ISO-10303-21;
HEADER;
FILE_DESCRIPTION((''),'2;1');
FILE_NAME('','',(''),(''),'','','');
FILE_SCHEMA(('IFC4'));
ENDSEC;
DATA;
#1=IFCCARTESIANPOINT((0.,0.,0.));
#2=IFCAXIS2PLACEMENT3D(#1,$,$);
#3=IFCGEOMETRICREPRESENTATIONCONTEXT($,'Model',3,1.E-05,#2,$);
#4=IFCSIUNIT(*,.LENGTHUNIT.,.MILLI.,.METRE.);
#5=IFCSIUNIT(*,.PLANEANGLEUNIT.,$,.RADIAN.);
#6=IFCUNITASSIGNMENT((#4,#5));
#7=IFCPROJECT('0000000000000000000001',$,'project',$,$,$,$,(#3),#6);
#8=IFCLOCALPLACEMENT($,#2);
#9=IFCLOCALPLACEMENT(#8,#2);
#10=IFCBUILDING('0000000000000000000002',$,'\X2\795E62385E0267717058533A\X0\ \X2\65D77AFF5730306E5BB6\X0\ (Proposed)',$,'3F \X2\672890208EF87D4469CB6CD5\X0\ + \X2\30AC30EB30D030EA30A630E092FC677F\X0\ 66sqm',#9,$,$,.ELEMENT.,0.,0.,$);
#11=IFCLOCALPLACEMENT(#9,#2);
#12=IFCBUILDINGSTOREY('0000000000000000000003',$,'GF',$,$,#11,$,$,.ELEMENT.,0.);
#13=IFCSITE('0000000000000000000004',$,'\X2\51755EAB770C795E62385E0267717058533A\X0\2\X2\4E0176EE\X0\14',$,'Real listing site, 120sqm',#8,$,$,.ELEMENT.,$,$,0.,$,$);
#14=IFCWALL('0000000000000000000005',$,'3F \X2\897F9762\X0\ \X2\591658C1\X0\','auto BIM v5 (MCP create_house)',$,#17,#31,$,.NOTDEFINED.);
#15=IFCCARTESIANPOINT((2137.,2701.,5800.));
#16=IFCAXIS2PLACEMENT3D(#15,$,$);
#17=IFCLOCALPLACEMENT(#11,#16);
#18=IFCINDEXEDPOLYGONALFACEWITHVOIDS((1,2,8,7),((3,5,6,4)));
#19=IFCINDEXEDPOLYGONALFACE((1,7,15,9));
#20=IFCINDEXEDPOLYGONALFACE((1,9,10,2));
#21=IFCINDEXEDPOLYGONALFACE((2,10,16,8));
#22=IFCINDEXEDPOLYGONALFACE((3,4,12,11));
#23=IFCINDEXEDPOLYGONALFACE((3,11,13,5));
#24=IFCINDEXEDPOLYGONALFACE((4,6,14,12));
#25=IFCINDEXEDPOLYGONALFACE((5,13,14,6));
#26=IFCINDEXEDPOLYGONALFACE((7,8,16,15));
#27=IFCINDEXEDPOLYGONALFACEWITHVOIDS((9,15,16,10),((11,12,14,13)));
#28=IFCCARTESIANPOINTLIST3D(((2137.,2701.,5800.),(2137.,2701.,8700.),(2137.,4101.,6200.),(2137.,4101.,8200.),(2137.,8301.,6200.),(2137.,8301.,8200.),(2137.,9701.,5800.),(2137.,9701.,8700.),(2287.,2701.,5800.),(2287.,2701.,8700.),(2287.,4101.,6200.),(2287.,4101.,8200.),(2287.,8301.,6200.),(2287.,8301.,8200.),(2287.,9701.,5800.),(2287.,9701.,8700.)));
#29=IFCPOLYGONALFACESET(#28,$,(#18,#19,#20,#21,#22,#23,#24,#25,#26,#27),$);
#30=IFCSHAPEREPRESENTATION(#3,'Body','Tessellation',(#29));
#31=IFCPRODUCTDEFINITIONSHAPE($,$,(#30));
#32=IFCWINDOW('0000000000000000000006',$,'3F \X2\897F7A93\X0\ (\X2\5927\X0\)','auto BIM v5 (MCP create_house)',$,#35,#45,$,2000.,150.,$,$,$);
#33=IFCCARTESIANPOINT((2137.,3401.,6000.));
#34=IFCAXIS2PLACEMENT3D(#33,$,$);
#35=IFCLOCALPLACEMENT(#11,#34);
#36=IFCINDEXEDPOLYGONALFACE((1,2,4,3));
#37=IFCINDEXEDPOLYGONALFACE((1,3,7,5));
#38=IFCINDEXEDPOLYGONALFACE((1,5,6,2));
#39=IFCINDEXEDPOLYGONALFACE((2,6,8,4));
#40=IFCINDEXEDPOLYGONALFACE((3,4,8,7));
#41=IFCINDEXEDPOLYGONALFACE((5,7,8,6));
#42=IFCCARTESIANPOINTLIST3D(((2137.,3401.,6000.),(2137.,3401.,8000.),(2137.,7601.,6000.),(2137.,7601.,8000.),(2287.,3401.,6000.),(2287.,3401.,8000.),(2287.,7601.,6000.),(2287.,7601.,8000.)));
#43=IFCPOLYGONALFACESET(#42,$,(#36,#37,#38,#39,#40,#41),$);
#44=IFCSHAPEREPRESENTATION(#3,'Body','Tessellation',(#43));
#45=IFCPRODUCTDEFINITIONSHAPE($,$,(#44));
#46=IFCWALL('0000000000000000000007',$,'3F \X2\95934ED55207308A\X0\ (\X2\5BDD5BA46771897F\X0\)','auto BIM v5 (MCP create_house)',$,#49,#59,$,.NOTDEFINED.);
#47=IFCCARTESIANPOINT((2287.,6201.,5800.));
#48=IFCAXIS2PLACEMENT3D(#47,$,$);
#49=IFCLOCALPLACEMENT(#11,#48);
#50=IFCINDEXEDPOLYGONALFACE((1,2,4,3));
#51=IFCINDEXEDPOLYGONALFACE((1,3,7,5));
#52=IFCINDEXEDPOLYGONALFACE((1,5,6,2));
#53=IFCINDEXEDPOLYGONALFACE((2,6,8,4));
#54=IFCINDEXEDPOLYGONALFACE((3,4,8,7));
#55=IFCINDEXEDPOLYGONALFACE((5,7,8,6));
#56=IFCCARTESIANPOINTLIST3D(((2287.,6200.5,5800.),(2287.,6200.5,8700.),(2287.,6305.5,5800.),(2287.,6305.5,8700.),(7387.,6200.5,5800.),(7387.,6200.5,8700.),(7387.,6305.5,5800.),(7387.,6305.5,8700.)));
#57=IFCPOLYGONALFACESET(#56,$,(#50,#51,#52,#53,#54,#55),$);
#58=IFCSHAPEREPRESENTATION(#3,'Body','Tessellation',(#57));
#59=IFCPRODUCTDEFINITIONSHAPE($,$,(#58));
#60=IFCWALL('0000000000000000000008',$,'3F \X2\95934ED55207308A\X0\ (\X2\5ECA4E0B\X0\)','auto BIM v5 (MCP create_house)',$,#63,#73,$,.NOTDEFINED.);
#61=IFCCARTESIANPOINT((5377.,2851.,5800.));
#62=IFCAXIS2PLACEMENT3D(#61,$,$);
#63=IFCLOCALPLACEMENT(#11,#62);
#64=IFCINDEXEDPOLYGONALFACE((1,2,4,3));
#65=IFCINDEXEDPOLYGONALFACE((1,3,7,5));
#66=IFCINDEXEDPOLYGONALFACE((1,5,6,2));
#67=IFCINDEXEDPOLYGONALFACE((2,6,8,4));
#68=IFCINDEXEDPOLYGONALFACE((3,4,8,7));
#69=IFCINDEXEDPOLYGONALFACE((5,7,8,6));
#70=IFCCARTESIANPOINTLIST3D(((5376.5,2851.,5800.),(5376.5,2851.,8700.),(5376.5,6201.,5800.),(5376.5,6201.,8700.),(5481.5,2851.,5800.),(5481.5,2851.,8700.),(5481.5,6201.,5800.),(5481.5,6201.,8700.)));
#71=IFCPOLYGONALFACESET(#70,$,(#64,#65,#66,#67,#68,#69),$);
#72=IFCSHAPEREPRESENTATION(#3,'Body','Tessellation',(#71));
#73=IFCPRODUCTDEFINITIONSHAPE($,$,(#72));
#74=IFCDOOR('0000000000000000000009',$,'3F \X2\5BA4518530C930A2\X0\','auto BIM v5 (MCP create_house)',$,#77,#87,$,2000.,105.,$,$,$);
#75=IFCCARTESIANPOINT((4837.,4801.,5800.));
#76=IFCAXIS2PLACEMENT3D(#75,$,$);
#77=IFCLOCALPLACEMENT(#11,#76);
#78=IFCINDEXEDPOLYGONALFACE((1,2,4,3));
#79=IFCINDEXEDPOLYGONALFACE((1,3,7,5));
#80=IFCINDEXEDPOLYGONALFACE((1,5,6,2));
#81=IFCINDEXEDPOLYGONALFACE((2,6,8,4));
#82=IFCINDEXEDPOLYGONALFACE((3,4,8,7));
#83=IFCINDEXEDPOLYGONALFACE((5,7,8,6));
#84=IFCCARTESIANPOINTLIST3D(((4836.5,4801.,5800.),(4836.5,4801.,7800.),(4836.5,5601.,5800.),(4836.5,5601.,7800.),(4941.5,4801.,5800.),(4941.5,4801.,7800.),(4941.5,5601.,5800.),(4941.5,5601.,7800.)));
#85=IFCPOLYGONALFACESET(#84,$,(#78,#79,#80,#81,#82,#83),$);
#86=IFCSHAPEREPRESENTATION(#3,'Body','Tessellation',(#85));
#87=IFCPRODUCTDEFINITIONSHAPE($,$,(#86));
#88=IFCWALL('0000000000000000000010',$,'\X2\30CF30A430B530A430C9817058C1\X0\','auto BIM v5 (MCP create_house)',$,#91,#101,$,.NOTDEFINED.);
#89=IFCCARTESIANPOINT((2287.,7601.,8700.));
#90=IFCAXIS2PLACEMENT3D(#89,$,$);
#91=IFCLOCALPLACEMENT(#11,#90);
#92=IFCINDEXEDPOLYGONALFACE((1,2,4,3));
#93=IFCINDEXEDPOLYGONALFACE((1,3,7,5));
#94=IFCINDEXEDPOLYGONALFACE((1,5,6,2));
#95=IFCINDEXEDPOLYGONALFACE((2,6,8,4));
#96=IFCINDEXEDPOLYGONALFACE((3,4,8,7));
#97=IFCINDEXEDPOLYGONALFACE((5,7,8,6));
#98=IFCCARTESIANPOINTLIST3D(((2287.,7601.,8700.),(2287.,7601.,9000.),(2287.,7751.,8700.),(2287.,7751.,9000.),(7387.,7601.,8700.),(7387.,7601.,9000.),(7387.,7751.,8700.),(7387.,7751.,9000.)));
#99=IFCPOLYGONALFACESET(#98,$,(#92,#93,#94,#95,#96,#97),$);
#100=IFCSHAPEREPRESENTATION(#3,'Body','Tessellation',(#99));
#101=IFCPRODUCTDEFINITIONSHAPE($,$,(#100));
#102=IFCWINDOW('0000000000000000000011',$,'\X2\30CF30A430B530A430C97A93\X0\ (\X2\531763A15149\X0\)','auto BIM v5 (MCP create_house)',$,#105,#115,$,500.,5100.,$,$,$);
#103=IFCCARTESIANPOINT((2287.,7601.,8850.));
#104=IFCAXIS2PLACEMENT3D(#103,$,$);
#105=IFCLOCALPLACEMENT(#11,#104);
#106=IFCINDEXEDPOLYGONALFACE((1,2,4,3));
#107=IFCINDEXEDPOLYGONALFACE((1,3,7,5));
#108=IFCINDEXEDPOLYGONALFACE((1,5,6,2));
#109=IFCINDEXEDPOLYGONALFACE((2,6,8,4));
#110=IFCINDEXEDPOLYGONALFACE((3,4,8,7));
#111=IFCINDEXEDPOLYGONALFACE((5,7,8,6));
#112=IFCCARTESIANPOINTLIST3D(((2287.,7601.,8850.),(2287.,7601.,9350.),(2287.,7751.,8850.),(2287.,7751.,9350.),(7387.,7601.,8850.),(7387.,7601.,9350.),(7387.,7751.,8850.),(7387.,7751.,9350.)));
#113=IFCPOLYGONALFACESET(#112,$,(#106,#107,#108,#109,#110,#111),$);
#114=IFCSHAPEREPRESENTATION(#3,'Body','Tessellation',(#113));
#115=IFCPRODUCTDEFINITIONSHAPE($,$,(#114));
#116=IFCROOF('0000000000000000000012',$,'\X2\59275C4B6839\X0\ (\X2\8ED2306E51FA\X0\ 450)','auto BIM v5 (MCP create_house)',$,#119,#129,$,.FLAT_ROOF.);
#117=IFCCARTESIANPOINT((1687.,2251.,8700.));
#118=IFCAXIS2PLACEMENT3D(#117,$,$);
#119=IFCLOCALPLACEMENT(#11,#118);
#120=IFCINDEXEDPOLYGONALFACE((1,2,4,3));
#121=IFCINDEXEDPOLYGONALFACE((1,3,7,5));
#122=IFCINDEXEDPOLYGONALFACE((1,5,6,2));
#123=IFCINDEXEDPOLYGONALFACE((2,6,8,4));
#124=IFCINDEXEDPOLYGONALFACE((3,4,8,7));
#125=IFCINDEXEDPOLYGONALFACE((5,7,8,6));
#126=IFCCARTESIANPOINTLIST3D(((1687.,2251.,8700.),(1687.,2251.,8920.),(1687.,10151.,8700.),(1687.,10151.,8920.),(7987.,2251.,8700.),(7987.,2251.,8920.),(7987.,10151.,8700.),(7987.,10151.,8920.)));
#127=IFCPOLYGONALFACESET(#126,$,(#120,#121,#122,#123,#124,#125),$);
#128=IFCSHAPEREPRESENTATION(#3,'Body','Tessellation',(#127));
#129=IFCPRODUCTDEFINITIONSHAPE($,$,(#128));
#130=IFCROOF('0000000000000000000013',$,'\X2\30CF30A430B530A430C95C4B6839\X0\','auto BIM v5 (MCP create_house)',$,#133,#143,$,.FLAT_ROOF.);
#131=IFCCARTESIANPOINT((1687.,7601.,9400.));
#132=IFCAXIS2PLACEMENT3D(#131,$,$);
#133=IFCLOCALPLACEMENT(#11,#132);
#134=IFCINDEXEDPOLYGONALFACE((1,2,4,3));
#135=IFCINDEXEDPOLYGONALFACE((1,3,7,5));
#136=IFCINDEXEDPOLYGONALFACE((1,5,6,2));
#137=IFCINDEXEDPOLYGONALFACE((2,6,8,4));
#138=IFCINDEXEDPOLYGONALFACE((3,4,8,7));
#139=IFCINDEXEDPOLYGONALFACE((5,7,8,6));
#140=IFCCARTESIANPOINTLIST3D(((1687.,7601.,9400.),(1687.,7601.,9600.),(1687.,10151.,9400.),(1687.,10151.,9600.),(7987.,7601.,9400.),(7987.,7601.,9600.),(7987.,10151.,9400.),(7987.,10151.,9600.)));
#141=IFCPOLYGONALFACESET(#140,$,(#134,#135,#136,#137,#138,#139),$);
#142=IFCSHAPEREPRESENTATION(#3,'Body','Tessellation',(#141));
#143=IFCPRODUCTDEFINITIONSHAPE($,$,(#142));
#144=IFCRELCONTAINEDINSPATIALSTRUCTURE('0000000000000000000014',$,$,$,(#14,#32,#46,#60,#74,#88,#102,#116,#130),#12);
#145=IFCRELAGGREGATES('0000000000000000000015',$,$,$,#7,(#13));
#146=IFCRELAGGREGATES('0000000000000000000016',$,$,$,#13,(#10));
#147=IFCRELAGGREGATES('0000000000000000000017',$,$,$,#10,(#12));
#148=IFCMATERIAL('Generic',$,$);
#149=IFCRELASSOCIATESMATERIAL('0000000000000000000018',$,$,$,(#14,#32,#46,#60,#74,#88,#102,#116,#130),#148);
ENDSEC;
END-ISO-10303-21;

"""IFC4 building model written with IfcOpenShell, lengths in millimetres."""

from ifc_helpers import new_model, si_unit, frame, frame_2d, origin, place, context, project, spatial, rectangle, extrude, material, element, fill, save


model = new_model("IFC4")

# Units and contexts
model_context = context("Model", 3, precision=1e-05, world=origin())
ifc_project = project(units=[si_unit("LENGTHUNIT", "METRE", prefix="MILLI"), si_unit("PLANEANGLEUNIT", "RADIAN")], contexts=[model_context])

# Site, building, storey
site_placement = place(None, origin())
site = spatial("IfcSite", under=ifc_project, at=site_placement, Name="兵庫県神戸市東灘区2丁目14", ObjectType="Real listing site, 120sqm", CompositionType="ELEMENT", RefElevation=0.0)
building_placement = place(site_placement, origin())
building = spatial("IfcBuilding", under=site, at=building_placement, Name="神戸市東灘区 旗竿地の家 (Proposed)", ObjectType="3F 木造軸組構法 + ガルバリウム鋼板 66sqm", CompositionType="ELEMENT", ElevationOfRefHeight=0.0, ElevationOfTerrain=0.0)
storey_placement = place(building_placement, origin())
storey = spatial("IfcBuildingStorey", under=building, at=storey_placement, Name="GF", CompositionType="ELEMENT", Elevation=0.0)

# Shared definitions
ifc_material = material(Name="Generic")

# Wall, opening, window
wall_1_placement = place(storey_placement, frame((2137.0, 2701.0, 5800.0)))
wall_1 = element("IfcWall", 1, at=wall_1_placement, inside=storey, material=ifc_material, Name="3F 西面 外壁", Description="auto BIM v5 (MCP create_house)", PredefinedType="NOTDEFINED", context=model_context, shape_type="SweptSolid", body=[
    extrude(rectangle(XDim=150.0, YDim=7000.0, at=frame_2d((75.0, 3500.0))), frame((2137.0, 2701.0, 5800.0)), (0.0, 0.0, 1.0), 2900.0),
])
opening_1_placement = place(storey_placement, frame((2137.0, 3401.0, 6000.0)))
opening_1 = element("IfcOpeningElement", 2, at=opening_1_placement, cuts=wall_1, PredefinedType="NOTDEFINED", context=model_context, shape_type="SweptSolid", body=[
    extrude(rectangle(XDim=150.0, YDim=4200.0, at=frame_2d((75.0, 2100.0))), frame((2137.0, 3401.0, 6000.0)), (0.0, 0.0, 1.0), 2000.0),
])
window_1_placement = place(storey_placement, frame((2137.0, 3401.0, 6000.0)))
window_1 = element("IfcWindow", 3, at=window_1_placement, inside=storey, material=ifc_material, Name="3F 西窓 (大)", Description="auto BIM v5 (MCP create_house)", OverallHeight=2000.0, OverallWidth=150.0, context=model_context, shape_type="SweptSolid", body=[
    extrude(rectangle(XDim=150.0, YDim=4200.0, at=frame_2d((75.0, 2100.0))), frame((2137.0, 3401.0, 6000.0)), (0.0, 0.0, 1.0), 2000.0),
])
fill(opening_1, window_1)

# Walls
wall_2_placement = place(storey_placement, frame((2287.0, 6201.0, 5800.0)))
element("IfcWall", 4, at=wall_2_placement, inside=storey, material=ifc_material, Name="3F 間仕切り (寝室東西)", Description="auto BIM v5 (MCP create_house)", PredefinedType="NOTDEFINED", context=model_context, shape_type="SweptSolid", body=[
    extrude(rectangle(XDim=5100.0, YDim=105.0, at=frame_2d((2550.0, 52.0))), frame((2287.0, 6201.0, 5800.0)), (0.0, 0.0, 1.0), 2900.0),
])
wall_3_placement = place(storey_placement, frame((5377.0, 2851.0, 5800.0)))
element("IfcWall", 5, at=wall_3_placement, inside=storey, material=ifc_material, Name="3F 間仕切り (廊下)", Description="auto BIM v5 (MCP create_house)", PredefinedType="NOTDEFINED", context=model_context, shape_type="SweptSolid", body=[
    extrude(rectangle(XDim=105.0, YDim=3350.0, at=frame_2d((52.0, 1675.0))), frame((5377.0, 2851.0, 5800.0)), (0.0, 0.0, 1.0), 2900.0),
])

# Door
door_1_placement = place(storey_placement, frame((4837.0, 4801.0, 5800.0)))
element("IfcDoor", 6, at=door_1_placement, inside=storey, material=ifc_material, Name="3F 室内ドア", Description="auto BIM v5 (MCP create_house)", OverallHeight=2000.0, OverallWidth=105.0, context=model_context, shape_type="SweptSolid", body=[
    extrude(rectangle(XDim=105.0, YDim=800.0, at=frame_2d((52.0, 400.0))), frame((4837.0, 4801.0, 5800.0)), (0.0, 0.0, 1.0), 2000.0),
])

# Wall, opening, window
wall_4_placement = place(storey_placement, frame((2287.0, 7601.0, 8700.0)))
wall_4 = element("IfcWall", 7, at=wall_4_placement, inside=storey, material=ifc_material, Name="ハイサイド腰壁", Description="auto BIM v5 (MCP create_house)", PredefinedType="NOTDEFINED", context=model_context, shape_type="SweptSolid", body=[
    extrude(rectangle(XDim=5100.0, YDim=150.0, at=frame_2d((2550.0, 75.0))), frame((2287.0, 7601.0, 8700.0)), (0.0, 0.0, 1.0), 700.0),
])
opening_2_placement = place(storey_placement, frame((2287.0, 7601.0, 8850.0)))
opening_2 = element("IfcOpeningElement", 8, at=opening_2_placement, cuts=wall_4, PredefinedType="NOTDEFINED", context=model_context, shape_type="SweptSolid", body=[
    extrude(rectangle(XDim=5100.0, YDim=150.0, at=frame_2d((2550.0, 75.0))), frame((2287.0, 7601.0, 8850.0)), (0.0, 0.0, 1.0), 500.0),
])
window_2_placement = place(storey_placement, frame((2287.0, 7601.0, 8850.0)))
window_2 = element("IfcWindow", 9, at=window_2_placement, inside=storey, material=ifc_material, Name="ハイサイド窓 (北採光)", Description="auto BIM v5 (MCP create_house)", OverallHeight=500.0, OverallWidth=5100.0, context=model_context, shape_type="SweptSolid", body=[
    extrude(rectangle(XDim=5100.0, YDim=150.0, at=frame_2d((2550.0, 75.0))), frame((2287.0, 7601.0, 8850.0)), (0.0, 0.0, 1.0), 500.0),
])
fill(opening_2, window_2)

# Roofs
roof_1_placement = place(storey_placement, frame((1687.0, 2251.0, 8700.0)))
element("IfcRoof", 10, at=roof_1_placement, inside=storey, material=ifc_material, Name="大屋根 (軒の出 450)", Description="auto BIM v5 (MCP create_house)", PredefinedType="FLAT_ROOF", context=model_context, shape_type="SweptSolid", body=[
    extrude(rectangle(XDim=6300.0, YDim=7900.0, at=frame_2d((3150.0, 3950.0))), frame((1687.0, 2251.0, 8700.0)), (0.0, 0.0, 1.0), 220.0),
])
roof_2_placement = place(storey_placement, frame((1687.0, 7601.0, 9400.0)))
element("IfcRoof", 11, at=roof_2_placement, inside=storey, material=ifc_material, Name="ハイサイド屋根", Description="auto BIM v5 (MCP create_house)", PredefinedType="FLAT_ROOF", context=model_context, shape_type="SweptSolid", body=[
    extrude(rectangle(XDim=6300.0, YDim=2550.0, at=frame_2d((3150.0, 1275.0))), frame((1687.0, 7601.0, 9400.0)), (0.0, 0.0, 1.0), 200.0),
])

save(model, "model.ifc")
